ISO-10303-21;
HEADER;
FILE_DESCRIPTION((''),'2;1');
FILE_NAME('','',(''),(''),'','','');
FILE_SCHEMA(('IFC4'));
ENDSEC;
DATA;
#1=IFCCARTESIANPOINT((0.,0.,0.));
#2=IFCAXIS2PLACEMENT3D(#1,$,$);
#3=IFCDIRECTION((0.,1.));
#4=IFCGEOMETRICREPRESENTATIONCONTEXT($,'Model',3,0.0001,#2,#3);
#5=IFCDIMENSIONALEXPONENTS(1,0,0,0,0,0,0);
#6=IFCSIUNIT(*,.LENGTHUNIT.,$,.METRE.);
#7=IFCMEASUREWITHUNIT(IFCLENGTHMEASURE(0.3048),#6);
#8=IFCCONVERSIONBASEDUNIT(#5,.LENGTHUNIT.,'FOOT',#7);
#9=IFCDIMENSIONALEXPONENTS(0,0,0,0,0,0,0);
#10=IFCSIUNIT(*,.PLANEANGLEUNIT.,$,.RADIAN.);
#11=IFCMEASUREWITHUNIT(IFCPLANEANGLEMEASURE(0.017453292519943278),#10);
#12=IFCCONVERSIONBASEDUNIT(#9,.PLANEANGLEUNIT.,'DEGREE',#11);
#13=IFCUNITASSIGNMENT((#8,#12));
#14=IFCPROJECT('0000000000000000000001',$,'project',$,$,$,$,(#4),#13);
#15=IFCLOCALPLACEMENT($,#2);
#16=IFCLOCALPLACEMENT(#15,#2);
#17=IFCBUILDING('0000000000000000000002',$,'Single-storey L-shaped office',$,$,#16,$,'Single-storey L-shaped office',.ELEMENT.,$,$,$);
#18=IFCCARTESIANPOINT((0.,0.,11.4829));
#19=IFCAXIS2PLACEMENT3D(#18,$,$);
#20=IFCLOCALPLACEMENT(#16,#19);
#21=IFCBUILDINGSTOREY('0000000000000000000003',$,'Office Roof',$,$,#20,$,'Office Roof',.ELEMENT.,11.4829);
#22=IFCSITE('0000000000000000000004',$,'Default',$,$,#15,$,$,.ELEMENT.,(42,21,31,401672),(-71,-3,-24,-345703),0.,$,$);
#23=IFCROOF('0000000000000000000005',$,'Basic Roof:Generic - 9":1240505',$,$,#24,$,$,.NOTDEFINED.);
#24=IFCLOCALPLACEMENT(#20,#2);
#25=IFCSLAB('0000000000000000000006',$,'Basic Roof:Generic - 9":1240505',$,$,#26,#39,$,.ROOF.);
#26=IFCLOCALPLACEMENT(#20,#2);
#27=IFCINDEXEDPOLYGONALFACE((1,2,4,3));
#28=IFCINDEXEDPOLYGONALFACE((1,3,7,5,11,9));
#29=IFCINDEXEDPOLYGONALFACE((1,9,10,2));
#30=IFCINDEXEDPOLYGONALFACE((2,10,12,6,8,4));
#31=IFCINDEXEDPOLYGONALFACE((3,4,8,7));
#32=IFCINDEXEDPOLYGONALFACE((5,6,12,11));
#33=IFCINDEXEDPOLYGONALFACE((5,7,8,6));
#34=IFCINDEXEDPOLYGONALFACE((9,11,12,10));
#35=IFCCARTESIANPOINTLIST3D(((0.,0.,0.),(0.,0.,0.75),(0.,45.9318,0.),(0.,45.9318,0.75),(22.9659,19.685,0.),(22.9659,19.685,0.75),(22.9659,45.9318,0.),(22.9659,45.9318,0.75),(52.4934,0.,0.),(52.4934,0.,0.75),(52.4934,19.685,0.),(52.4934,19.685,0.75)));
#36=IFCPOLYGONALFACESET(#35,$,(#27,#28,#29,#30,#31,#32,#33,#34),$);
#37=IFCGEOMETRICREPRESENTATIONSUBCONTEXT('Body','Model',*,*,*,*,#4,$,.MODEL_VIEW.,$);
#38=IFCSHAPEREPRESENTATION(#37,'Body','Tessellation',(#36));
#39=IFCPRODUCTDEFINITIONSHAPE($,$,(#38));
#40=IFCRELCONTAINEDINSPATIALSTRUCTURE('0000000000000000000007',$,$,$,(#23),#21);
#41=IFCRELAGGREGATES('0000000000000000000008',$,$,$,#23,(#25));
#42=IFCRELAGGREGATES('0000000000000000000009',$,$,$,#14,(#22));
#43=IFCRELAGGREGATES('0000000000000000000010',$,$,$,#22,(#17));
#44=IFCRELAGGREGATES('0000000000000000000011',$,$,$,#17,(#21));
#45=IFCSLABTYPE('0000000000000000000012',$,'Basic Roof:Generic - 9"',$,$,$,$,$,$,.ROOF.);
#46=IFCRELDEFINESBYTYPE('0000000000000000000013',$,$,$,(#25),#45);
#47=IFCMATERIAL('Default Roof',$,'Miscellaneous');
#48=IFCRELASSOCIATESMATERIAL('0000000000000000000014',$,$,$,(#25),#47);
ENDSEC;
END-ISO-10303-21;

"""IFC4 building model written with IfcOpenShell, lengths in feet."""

from ifc_helpers import new_model, entity, si_unit, converted_unit, direction, frame, origin, place, context, subcontext, project, spatial, indexed_curve, outline, extrude, material, type_object, element, aggregate, save


model = new_model("IFC4")

# Units and contexts
model_context = context("Model", 3, precision=0.0001, world=origin(), true_north=direction((0.0, 1.0)))
body_context = subcontext(model_context, "Body", "Model", "MODEL_VIEW")
ifc_project = project(units=[converted_unit("LENGTHUNIT", "FOOT", entity("IfcLengthMeasure", 0.3048), si_unit("LENGTHUNIT", "METRE"), dimensions=[1, 0, 0, 0, 0, 0, 0]), converted_unit("PLANEANGLEUNIT", "DEGREE", entity("IfcPlaneAngleMeasure", 0.017453292519943278), si_unit("PLANEANGLEUNIT", "RADIAN"), dimensions=[0, 0, 0, 0, 0, 0, 0])], contexts=[model_context])

# Site, building, storey
site_placement = place(None, origin())
site = spatial("IfcSite", under=ifc_project, at=site_placement, Name="Default", CompositionType="ELEMENT", RefLatitude=(42, 21, 31, 401672), RefLongitude=(-71, -3, -24, -345703), RefElevation=0.0)
building_placement = place(site_placement, origin())
building = spatial("IfcBuilding", under=site, at=building_placement, Name="Single-storey L-shaped office", LongName="Single-storey L-shaped office", CompositionType="ELEMENT")
storey_placement = place(building_placement, frame((0.0, 0.0, 11.4829)))
storey = spatial("IfcBuildingStorey", under=building, at=storey_placement, Name="Office Roof", LongName="Office Roof", CompositionType="ELEMENT", Elevation=11.4829)

# Roof, slab
roof_placement = place(storey_placement, origin())
roof = element("IfcRoof", 1, at=roof_placement, inside=storey, Name="Basic Roof:Generic - 9\":1240505", PredefinedType="NOTDEFINED")
ifc_material = material(Name="Default Roof", Category="Miscellaneous")
slab_type = type_object("IfcSlabType", Name="Basic Roof:Generic - 9\"", PredefinedType="ROOF")
slab_placement = place(roof_placement, origin())
slab = element("IfcSlab", 2, at=slab_placement, type_object=slab_type, material=ifc_material, Name="Basic Roof:Generic - 9\":1240505", PredefinedType="ROOF", context=body_context, shape_type="SweptSolid", body=[
    extrude(outline(indexed_curve([(26.2467, -22.9659), (26.2467, -3.2808), (-3.2808, -3.2808), (-3.2808, 22.9659), (-26.2467, 22.9659), (-26.2467, -22.9659), (26.2467, -22.9659)], self_intersect=False)), frame((26.2467, 22.9659, 0.0)), (0.0, 0.0, 1.0), 0.75),
])
aggregate(roof, [slab])

save(model, "model.ifc")
